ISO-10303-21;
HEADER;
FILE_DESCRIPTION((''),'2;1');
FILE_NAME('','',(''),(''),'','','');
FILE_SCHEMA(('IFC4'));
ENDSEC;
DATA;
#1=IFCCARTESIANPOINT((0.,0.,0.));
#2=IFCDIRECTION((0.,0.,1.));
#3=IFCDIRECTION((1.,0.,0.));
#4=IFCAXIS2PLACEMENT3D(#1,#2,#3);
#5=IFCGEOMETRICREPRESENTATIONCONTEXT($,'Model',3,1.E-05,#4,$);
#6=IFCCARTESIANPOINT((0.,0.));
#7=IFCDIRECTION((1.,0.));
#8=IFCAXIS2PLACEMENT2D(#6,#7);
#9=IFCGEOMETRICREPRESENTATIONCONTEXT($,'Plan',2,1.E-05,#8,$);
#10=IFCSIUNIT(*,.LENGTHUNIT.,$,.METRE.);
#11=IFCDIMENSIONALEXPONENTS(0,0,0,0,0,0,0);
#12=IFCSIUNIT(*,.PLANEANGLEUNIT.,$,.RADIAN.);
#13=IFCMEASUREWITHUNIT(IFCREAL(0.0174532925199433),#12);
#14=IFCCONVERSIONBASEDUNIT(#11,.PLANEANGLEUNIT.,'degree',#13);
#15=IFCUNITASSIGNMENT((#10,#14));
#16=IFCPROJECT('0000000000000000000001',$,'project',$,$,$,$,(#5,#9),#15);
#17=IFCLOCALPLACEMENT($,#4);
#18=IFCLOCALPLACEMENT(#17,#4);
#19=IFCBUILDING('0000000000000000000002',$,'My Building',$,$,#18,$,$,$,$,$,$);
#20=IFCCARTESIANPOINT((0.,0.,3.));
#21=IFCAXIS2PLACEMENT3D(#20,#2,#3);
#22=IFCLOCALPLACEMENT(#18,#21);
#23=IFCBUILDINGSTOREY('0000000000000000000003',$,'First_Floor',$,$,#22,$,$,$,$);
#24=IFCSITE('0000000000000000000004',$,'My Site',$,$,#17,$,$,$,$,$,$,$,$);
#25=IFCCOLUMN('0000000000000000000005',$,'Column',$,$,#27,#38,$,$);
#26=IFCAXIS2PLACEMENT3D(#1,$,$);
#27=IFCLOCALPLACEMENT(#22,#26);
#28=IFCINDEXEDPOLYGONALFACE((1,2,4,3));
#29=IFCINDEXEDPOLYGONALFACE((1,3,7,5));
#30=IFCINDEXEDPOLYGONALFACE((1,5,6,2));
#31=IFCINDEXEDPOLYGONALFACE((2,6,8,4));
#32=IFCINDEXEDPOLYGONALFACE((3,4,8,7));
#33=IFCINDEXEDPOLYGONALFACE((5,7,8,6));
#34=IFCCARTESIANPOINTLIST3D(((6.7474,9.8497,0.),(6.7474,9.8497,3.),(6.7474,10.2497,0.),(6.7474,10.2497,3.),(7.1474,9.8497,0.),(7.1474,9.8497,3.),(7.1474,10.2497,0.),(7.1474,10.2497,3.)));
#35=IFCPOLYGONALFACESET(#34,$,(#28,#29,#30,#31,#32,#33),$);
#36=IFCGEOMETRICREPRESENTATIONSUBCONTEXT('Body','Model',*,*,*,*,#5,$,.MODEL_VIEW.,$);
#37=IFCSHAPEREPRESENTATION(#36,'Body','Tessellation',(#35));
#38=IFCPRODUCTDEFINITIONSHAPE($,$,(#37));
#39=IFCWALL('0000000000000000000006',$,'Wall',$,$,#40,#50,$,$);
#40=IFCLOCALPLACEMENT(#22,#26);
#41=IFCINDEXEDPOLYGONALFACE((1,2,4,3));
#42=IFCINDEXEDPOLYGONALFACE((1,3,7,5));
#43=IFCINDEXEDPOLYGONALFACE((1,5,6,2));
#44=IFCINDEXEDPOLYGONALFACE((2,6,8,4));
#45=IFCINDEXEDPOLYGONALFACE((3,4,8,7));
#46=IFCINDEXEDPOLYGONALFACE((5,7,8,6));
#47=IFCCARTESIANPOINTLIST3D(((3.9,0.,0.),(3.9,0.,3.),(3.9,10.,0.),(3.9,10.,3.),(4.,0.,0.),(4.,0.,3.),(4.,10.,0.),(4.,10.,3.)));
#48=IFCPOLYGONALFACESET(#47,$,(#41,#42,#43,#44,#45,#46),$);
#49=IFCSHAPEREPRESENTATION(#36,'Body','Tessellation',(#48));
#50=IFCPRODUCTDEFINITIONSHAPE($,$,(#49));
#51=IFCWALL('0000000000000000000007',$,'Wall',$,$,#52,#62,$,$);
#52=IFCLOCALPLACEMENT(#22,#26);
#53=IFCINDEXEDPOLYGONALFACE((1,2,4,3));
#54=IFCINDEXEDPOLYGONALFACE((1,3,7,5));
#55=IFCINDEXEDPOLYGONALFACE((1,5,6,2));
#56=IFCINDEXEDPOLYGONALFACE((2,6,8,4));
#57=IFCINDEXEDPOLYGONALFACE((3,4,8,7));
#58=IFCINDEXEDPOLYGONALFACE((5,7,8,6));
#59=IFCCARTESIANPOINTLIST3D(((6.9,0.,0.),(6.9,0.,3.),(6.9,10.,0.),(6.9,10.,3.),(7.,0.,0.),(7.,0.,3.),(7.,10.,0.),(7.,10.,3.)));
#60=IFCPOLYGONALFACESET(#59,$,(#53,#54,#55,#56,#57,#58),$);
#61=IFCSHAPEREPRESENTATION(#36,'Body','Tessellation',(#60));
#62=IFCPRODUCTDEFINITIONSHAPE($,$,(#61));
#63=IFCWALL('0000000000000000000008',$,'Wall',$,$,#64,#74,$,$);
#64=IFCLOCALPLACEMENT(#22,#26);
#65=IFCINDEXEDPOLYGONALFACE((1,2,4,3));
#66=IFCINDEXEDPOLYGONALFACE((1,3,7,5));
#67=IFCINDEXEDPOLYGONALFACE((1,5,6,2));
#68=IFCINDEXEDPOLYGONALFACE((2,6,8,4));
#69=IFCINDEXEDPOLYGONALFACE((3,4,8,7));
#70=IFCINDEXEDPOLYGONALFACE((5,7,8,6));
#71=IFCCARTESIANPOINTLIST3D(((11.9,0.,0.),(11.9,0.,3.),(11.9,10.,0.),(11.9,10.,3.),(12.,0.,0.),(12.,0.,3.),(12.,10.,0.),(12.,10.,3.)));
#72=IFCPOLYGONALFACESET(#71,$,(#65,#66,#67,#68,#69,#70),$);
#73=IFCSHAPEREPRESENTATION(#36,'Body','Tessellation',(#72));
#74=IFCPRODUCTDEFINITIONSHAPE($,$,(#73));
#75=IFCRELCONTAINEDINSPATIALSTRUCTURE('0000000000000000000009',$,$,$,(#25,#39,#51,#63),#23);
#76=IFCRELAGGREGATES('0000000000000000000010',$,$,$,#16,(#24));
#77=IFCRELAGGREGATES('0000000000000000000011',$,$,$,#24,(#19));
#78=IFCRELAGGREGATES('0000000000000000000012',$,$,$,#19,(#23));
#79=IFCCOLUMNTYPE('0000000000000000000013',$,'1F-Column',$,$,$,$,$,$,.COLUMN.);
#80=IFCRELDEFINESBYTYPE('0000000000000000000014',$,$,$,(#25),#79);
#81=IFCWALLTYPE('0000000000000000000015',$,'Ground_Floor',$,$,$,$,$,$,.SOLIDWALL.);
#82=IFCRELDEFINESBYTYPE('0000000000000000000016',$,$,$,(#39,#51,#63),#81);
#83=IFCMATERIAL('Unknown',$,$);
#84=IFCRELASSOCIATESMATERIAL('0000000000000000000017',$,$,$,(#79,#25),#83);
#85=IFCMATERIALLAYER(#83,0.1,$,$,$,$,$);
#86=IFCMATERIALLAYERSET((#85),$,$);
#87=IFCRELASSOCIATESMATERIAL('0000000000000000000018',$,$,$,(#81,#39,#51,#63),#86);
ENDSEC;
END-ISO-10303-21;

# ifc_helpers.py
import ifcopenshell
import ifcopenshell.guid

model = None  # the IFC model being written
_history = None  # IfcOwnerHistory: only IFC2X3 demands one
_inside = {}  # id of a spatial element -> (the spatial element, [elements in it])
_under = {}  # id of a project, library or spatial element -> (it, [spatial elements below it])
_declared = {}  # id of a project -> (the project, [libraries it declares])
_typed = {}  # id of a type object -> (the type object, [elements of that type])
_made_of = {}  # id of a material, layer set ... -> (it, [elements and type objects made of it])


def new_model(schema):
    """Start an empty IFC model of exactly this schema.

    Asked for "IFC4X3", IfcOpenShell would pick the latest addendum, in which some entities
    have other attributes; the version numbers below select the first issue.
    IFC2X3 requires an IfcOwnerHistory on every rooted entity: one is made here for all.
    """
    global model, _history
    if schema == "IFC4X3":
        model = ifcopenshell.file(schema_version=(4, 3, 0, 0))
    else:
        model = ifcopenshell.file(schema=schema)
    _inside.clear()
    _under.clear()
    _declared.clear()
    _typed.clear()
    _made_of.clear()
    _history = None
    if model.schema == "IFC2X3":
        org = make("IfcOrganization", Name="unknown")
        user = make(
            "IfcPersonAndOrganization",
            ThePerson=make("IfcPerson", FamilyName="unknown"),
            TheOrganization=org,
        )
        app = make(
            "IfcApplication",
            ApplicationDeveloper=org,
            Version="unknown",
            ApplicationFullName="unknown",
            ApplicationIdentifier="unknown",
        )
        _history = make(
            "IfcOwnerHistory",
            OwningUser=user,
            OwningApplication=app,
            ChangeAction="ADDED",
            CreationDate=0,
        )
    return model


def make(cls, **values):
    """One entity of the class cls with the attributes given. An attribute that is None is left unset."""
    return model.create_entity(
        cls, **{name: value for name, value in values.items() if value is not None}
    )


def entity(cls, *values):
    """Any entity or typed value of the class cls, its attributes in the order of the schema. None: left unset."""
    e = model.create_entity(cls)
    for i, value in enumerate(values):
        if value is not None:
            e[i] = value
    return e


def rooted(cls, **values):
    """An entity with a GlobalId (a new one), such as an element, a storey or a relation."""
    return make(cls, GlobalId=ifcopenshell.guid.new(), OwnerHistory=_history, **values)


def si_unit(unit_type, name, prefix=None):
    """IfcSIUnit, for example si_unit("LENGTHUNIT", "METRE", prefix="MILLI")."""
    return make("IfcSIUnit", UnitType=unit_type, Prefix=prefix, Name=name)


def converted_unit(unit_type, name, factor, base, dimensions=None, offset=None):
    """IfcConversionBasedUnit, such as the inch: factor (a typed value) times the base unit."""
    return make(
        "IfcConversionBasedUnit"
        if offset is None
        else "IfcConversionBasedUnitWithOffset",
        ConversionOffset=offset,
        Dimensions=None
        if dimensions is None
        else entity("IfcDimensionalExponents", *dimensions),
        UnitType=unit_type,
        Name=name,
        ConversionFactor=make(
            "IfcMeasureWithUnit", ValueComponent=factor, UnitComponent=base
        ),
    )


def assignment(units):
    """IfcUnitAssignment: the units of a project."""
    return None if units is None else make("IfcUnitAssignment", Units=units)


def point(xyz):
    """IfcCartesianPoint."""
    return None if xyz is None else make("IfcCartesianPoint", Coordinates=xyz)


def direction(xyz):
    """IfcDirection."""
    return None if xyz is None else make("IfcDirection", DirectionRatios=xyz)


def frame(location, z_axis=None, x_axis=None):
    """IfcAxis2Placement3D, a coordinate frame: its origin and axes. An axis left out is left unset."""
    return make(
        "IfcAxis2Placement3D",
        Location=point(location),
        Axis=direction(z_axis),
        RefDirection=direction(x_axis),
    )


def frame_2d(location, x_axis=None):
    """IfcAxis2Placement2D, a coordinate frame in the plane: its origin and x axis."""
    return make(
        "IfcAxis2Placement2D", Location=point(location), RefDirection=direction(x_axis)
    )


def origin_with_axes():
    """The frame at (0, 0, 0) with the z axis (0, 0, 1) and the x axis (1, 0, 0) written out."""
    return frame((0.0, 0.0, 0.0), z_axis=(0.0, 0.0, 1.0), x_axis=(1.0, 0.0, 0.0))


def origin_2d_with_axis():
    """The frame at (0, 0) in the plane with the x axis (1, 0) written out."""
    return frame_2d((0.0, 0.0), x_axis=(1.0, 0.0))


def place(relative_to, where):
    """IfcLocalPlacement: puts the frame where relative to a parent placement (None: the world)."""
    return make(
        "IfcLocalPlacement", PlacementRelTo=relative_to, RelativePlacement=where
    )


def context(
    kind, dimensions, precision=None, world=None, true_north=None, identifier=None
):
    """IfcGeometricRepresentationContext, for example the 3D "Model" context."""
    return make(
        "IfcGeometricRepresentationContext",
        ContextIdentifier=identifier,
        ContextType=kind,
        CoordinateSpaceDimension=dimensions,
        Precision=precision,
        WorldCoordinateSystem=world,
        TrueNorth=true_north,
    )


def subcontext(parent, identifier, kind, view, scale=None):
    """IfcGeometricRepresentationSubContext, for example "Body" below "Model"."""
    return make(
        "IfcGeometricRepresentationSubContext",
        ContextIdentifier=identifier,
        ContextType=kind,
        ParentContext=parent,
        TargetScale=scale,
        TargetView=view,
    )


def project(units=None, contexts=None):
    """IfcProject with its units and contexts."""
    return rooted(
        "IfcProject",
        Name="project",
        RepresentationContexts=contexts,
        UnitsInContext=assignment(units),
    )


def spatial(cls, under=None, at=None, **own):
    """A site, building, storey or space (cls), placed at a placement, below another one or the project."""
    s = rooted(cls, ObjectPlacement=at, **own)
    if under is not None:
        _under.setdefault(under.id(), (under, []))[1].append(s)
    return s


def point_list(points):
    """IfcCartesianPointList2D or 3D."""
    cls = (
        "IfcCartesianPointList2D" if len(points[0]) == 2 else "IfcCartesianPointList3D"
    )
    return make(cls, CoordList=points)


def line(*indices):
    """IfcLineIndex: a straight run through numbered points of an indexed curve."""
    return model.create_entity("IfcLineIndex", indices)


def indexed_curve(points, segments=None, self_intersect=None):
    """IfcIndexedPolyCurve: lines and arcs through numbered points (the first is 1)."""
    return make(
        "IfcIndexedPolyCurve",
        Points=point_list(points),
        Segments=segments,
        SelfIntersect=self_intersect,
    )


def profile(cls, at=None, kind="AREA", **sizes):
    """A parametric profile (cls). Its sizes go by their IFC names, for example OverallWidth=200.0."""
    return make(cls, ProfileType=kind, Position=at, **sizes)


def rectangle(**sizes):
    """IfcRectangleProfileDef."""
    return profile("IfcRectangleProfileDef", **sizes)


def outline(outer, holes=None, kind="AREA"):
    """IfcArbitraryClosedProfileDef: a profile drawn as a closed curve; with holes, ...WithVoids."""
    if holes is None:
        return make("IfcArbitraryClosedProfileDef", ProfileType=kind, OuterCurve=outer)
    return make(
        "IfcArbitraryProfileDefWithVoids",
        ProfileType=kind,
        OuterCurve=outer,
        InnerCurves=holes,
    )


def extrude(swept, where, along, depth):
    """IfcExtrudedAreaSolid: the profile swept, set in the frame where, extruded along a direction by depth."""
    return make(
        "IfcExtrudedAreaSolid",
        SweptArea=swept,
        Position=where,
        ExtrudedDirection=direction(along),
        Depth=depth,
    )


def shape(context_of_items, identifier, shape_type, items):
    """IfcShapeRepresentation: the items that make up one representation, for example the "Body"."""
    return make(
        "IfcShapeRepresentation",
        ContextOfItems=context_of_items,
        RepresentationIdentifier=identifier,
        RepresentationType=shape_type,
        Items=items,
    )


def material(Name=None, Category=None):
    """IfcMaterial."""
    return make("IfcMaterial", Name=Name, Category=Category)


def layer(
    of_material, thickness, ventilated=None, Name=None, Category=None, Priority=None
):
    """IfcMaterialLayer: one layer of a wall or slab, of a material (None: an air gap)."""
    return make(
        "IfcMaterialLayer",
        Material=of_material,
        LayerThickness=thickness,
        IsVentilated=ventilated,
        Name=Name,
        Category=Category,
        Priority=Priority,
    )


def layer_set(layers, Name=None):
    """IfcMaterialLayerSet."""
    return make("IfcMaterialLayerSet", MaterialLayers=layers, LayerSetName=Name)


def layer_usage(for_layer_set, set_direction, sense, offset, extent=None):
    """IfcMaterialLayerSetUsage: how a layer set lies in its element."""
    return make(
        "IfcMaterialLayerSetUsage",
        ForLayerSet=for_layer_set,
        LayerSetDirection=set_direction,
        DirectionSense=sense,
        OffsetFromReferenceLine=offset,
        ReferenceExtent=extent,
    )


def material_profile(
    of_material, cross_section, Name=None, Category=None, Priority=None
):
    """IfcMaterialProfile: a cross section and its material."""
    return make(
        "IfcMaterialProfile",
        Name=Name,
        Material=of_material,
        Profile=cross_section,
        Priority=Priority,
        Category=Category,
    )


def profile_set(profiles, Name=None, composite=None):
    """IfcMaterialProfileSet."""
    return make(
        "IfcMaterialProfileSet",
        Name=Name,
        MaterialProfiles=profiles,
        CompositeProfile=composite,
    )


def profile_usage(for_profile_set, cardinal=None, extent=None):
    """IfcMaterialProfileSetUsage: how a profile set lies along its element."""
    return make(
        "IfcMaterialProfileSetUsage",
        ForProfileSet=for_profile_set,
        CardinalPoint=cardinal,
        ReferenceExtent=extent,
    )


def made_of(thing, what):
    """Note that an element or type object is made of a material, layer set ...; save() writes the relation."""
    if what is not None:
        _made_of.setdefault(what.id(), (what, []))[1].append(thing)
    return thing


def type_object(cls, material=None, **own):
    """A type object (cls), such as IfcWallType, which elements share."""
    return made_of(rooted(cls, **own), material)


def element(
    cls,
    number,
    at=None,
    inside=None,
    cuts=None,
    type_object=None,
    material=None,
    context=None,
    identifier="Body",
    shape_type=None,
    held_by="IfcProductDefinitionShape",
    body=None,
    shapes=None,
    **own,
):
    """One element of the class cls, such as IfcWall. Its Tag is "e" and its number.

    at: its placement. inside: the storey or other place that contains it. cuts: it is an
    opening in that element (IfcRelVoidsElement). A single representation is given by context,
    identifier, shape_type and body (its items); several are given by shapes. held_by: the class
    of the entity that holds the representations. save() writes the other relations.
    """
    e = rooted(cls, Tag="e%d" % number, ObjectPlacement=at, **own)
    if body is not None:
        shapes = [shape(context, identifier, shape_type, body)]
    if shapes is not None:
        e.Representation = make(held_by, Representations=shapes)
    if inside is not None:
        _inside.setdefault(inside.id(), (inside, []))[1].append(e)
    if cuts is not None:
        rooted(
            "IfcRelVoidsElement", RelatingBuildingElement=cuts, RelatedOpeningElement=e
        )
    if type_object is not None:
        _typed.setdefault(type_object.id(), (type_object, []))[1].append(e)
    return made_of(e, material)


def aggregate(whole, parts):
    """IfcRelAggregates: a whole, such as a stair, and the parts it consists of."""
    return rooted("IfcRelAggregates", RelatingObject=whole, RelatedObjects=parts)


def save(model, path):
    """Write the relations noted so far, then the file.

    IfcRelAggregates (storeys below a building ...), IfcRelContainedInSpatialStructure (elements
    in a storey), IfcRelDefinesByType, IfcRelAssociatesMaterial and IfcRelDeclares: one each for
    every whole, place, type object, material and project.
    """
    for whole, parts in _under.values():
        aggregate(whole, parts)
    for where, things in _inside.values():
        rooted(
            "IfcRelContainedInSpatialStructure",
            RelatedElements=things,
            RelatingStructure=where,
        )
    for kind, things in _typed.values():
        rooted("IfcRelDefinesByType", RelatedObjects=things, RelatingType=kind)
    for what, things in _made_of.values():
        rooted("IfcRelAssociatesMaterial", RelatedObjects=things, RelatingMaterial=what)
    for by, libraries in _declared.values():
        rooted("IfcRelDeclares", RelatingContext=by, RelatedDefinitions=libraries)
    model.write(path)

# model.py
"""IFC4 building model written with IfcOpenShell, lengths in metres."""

from ifc_helpers import new_model, entity, si_unit, converted_unit, frame, origin_with_axes, origin_2d_with_axis, place, context, subcontext, project, spatial, line, indexed_curve, rectangle, outline, extrude, material, layer, layer_set, layer_usage, material_profile, profile_set, profile_usage, type_object, element, save


model = new_model("IFC4")

# Units and contexts
model_context = context("Model", 3, precision=1e-05, world=origin_with_axes())
plan_context = context("Plan", 2, precision=1e-05, world=origin_2d_with_axis())
body_context = subcontext(model_context, "Body", "Model", "MODEL_VIEW")
ifc_project = project(units=[si_unit("LENGTHUNIT", "METRE"), converted_unit("PLANEANGLEUNIT", "degree", entity("IfcReal", 0.0174532925199433), si_unit("PLANEANGLEUNIT", "RADIAN"), dimensions=[0, 0, 0, 0, 0, 0, 0])], contexts=[model_context, plan_context])

# Site, building, storey
site_placement = place(None, origin_with_axes())
site = spatial("IfcSite", under=ifc_project, at=site_placement, Name="My Site")
building_placement = place(site_placement, origin_with_axes())
building = spatial("IfcBuilding", under=site, at=building_placement, Name="My Building")
storey_placement = place(building_placement, frame((0.0, 0.0, 3.0), z_axis=(0.0, 0.0, 1.0), x_axis=(1.0, 0.0, 0.0)))
storey = spatial("IfcBuildingStorey", under=building, at=storey_placement, Name="First_Floor")

# Column
ifc_material = material(Name="Unknown")
ifc_material_profile = material_profile(ifc_material, rectangle(XDim=0.4, YDim=0.4))
ifc_profile_set = profile_set([ifc_material_profile])
ifc_profile_usage = profile_usage(ifc_profile_set, cardinal=5)
column_type = type_object("IfcColumnType", Name="1F-Column", PredefinedType="COLUMN", material=ifc_profile_set)
column_placement = place(storey_placement, frame((6.9474, 10.0497, 0.0), z_axis=(0.0, 0.0, 1.0), x_axis=(1.0, 0.0, 0.0)))
element("IfcColumn", 1, at=column_placement, inside=storey, type_object=column_type, material=ifc_profile_usage, Name="Column", context=body_context, shape_type="SweptSolid", body=[
    extrude(rectangle(XDim=0.4, YDim=0.4), origin_with_axes(), (0.0, 0.0, 1.0), 3.0),
])

# Walls
ifc_layer = layer(ifc_material, 0.1)
ifc_layer_set = layer_set([ifc_layer])
ifc_layer_usage_1 = layer_usage(ifc_layer_set, "AXIS2", "POSITIVE", 0.0)
wall_type = type_object("IfcWallType", Name="Ground_Floor", PredefinedType="SOLIDWALL", material=ifc_layer_set)
wall_1_placement = place(storey_placement, frame((3.9, 10.0, 0.0), z_axis=(0.0, 0.0, 1.0), x_axis=(0.0, -1.0, 0.0)))
element("IfcWall", 2, at=wall_1_placement, inside=storey, type_object=wall_type, material=ifc_layer_usage_1, Name="Wall", context=body_context, shape_type="SweptSolid", body=[
    extrude(outline(indexed_curve([(0.0, 0.0), (0.0, 0.1), (10.0, 0.1), (10.0, 0.0)], segments=[line(1, 2, 3, 4, 1)])), origin_with_axes(), (0.0, 0.0, 1.0), 3.0),
])
ifc_layer_usage_2 = layer_usage(ifc_layer_set, "AXIS2", "POSITIVE", 0.0)
wall_2_placement = place(storey_placement, frame((6.9, 10.0, 0.0), z_axis=(0.0, 0.0, 1.0), x_axis=(0.0, -1.0, 0.0)))
element("IfcWall", 3, at=wall_2_placement, inside=storey, type_object=wall_type, material=ifc_layer_usage_2, Name="Wall", context=body_context, shape_type="SweptSolid", body=[
    extrude(outline(indexed_curve([(0.0, 0.0), (0.0, 0.1), (10.0, 0.1), (10.0, 0.0)], segments=[line(1, 2, 3, 4, 1)])), origin_with_axes(), (0.0, 0.0, 1.0), 3.0),
])
ifc_layer_usage_3 = layer_usage(ifc_layer_set, "AXIS2", "POSITIVE", 0.0)
wall_3_placement = place(storey_placement, frame((11.9, 10.0, 0.0), z_axis=(0.0, 0.0, 1.0), x_axis=(0.0, -1.0, 0.0)))
element("IfcWall", 4, at=wall_3_placement, inside=storey, type_object=wall_type, material=ifc_layer_usage_3, Name="Wall", context=body_context, shape_type="SweptSolid", body=[
    extrude(outline(indexed_curve([(0.0, 0.0), (0.0, 0.1), (10.0, 0.1), (10.0, 0.0)], segments=[line(1, 2, 3, 4, 1)])), origin_with_axes(), (0.0, 0.0, 1.0), 3.0),
])

save(model, "model.ifc")
